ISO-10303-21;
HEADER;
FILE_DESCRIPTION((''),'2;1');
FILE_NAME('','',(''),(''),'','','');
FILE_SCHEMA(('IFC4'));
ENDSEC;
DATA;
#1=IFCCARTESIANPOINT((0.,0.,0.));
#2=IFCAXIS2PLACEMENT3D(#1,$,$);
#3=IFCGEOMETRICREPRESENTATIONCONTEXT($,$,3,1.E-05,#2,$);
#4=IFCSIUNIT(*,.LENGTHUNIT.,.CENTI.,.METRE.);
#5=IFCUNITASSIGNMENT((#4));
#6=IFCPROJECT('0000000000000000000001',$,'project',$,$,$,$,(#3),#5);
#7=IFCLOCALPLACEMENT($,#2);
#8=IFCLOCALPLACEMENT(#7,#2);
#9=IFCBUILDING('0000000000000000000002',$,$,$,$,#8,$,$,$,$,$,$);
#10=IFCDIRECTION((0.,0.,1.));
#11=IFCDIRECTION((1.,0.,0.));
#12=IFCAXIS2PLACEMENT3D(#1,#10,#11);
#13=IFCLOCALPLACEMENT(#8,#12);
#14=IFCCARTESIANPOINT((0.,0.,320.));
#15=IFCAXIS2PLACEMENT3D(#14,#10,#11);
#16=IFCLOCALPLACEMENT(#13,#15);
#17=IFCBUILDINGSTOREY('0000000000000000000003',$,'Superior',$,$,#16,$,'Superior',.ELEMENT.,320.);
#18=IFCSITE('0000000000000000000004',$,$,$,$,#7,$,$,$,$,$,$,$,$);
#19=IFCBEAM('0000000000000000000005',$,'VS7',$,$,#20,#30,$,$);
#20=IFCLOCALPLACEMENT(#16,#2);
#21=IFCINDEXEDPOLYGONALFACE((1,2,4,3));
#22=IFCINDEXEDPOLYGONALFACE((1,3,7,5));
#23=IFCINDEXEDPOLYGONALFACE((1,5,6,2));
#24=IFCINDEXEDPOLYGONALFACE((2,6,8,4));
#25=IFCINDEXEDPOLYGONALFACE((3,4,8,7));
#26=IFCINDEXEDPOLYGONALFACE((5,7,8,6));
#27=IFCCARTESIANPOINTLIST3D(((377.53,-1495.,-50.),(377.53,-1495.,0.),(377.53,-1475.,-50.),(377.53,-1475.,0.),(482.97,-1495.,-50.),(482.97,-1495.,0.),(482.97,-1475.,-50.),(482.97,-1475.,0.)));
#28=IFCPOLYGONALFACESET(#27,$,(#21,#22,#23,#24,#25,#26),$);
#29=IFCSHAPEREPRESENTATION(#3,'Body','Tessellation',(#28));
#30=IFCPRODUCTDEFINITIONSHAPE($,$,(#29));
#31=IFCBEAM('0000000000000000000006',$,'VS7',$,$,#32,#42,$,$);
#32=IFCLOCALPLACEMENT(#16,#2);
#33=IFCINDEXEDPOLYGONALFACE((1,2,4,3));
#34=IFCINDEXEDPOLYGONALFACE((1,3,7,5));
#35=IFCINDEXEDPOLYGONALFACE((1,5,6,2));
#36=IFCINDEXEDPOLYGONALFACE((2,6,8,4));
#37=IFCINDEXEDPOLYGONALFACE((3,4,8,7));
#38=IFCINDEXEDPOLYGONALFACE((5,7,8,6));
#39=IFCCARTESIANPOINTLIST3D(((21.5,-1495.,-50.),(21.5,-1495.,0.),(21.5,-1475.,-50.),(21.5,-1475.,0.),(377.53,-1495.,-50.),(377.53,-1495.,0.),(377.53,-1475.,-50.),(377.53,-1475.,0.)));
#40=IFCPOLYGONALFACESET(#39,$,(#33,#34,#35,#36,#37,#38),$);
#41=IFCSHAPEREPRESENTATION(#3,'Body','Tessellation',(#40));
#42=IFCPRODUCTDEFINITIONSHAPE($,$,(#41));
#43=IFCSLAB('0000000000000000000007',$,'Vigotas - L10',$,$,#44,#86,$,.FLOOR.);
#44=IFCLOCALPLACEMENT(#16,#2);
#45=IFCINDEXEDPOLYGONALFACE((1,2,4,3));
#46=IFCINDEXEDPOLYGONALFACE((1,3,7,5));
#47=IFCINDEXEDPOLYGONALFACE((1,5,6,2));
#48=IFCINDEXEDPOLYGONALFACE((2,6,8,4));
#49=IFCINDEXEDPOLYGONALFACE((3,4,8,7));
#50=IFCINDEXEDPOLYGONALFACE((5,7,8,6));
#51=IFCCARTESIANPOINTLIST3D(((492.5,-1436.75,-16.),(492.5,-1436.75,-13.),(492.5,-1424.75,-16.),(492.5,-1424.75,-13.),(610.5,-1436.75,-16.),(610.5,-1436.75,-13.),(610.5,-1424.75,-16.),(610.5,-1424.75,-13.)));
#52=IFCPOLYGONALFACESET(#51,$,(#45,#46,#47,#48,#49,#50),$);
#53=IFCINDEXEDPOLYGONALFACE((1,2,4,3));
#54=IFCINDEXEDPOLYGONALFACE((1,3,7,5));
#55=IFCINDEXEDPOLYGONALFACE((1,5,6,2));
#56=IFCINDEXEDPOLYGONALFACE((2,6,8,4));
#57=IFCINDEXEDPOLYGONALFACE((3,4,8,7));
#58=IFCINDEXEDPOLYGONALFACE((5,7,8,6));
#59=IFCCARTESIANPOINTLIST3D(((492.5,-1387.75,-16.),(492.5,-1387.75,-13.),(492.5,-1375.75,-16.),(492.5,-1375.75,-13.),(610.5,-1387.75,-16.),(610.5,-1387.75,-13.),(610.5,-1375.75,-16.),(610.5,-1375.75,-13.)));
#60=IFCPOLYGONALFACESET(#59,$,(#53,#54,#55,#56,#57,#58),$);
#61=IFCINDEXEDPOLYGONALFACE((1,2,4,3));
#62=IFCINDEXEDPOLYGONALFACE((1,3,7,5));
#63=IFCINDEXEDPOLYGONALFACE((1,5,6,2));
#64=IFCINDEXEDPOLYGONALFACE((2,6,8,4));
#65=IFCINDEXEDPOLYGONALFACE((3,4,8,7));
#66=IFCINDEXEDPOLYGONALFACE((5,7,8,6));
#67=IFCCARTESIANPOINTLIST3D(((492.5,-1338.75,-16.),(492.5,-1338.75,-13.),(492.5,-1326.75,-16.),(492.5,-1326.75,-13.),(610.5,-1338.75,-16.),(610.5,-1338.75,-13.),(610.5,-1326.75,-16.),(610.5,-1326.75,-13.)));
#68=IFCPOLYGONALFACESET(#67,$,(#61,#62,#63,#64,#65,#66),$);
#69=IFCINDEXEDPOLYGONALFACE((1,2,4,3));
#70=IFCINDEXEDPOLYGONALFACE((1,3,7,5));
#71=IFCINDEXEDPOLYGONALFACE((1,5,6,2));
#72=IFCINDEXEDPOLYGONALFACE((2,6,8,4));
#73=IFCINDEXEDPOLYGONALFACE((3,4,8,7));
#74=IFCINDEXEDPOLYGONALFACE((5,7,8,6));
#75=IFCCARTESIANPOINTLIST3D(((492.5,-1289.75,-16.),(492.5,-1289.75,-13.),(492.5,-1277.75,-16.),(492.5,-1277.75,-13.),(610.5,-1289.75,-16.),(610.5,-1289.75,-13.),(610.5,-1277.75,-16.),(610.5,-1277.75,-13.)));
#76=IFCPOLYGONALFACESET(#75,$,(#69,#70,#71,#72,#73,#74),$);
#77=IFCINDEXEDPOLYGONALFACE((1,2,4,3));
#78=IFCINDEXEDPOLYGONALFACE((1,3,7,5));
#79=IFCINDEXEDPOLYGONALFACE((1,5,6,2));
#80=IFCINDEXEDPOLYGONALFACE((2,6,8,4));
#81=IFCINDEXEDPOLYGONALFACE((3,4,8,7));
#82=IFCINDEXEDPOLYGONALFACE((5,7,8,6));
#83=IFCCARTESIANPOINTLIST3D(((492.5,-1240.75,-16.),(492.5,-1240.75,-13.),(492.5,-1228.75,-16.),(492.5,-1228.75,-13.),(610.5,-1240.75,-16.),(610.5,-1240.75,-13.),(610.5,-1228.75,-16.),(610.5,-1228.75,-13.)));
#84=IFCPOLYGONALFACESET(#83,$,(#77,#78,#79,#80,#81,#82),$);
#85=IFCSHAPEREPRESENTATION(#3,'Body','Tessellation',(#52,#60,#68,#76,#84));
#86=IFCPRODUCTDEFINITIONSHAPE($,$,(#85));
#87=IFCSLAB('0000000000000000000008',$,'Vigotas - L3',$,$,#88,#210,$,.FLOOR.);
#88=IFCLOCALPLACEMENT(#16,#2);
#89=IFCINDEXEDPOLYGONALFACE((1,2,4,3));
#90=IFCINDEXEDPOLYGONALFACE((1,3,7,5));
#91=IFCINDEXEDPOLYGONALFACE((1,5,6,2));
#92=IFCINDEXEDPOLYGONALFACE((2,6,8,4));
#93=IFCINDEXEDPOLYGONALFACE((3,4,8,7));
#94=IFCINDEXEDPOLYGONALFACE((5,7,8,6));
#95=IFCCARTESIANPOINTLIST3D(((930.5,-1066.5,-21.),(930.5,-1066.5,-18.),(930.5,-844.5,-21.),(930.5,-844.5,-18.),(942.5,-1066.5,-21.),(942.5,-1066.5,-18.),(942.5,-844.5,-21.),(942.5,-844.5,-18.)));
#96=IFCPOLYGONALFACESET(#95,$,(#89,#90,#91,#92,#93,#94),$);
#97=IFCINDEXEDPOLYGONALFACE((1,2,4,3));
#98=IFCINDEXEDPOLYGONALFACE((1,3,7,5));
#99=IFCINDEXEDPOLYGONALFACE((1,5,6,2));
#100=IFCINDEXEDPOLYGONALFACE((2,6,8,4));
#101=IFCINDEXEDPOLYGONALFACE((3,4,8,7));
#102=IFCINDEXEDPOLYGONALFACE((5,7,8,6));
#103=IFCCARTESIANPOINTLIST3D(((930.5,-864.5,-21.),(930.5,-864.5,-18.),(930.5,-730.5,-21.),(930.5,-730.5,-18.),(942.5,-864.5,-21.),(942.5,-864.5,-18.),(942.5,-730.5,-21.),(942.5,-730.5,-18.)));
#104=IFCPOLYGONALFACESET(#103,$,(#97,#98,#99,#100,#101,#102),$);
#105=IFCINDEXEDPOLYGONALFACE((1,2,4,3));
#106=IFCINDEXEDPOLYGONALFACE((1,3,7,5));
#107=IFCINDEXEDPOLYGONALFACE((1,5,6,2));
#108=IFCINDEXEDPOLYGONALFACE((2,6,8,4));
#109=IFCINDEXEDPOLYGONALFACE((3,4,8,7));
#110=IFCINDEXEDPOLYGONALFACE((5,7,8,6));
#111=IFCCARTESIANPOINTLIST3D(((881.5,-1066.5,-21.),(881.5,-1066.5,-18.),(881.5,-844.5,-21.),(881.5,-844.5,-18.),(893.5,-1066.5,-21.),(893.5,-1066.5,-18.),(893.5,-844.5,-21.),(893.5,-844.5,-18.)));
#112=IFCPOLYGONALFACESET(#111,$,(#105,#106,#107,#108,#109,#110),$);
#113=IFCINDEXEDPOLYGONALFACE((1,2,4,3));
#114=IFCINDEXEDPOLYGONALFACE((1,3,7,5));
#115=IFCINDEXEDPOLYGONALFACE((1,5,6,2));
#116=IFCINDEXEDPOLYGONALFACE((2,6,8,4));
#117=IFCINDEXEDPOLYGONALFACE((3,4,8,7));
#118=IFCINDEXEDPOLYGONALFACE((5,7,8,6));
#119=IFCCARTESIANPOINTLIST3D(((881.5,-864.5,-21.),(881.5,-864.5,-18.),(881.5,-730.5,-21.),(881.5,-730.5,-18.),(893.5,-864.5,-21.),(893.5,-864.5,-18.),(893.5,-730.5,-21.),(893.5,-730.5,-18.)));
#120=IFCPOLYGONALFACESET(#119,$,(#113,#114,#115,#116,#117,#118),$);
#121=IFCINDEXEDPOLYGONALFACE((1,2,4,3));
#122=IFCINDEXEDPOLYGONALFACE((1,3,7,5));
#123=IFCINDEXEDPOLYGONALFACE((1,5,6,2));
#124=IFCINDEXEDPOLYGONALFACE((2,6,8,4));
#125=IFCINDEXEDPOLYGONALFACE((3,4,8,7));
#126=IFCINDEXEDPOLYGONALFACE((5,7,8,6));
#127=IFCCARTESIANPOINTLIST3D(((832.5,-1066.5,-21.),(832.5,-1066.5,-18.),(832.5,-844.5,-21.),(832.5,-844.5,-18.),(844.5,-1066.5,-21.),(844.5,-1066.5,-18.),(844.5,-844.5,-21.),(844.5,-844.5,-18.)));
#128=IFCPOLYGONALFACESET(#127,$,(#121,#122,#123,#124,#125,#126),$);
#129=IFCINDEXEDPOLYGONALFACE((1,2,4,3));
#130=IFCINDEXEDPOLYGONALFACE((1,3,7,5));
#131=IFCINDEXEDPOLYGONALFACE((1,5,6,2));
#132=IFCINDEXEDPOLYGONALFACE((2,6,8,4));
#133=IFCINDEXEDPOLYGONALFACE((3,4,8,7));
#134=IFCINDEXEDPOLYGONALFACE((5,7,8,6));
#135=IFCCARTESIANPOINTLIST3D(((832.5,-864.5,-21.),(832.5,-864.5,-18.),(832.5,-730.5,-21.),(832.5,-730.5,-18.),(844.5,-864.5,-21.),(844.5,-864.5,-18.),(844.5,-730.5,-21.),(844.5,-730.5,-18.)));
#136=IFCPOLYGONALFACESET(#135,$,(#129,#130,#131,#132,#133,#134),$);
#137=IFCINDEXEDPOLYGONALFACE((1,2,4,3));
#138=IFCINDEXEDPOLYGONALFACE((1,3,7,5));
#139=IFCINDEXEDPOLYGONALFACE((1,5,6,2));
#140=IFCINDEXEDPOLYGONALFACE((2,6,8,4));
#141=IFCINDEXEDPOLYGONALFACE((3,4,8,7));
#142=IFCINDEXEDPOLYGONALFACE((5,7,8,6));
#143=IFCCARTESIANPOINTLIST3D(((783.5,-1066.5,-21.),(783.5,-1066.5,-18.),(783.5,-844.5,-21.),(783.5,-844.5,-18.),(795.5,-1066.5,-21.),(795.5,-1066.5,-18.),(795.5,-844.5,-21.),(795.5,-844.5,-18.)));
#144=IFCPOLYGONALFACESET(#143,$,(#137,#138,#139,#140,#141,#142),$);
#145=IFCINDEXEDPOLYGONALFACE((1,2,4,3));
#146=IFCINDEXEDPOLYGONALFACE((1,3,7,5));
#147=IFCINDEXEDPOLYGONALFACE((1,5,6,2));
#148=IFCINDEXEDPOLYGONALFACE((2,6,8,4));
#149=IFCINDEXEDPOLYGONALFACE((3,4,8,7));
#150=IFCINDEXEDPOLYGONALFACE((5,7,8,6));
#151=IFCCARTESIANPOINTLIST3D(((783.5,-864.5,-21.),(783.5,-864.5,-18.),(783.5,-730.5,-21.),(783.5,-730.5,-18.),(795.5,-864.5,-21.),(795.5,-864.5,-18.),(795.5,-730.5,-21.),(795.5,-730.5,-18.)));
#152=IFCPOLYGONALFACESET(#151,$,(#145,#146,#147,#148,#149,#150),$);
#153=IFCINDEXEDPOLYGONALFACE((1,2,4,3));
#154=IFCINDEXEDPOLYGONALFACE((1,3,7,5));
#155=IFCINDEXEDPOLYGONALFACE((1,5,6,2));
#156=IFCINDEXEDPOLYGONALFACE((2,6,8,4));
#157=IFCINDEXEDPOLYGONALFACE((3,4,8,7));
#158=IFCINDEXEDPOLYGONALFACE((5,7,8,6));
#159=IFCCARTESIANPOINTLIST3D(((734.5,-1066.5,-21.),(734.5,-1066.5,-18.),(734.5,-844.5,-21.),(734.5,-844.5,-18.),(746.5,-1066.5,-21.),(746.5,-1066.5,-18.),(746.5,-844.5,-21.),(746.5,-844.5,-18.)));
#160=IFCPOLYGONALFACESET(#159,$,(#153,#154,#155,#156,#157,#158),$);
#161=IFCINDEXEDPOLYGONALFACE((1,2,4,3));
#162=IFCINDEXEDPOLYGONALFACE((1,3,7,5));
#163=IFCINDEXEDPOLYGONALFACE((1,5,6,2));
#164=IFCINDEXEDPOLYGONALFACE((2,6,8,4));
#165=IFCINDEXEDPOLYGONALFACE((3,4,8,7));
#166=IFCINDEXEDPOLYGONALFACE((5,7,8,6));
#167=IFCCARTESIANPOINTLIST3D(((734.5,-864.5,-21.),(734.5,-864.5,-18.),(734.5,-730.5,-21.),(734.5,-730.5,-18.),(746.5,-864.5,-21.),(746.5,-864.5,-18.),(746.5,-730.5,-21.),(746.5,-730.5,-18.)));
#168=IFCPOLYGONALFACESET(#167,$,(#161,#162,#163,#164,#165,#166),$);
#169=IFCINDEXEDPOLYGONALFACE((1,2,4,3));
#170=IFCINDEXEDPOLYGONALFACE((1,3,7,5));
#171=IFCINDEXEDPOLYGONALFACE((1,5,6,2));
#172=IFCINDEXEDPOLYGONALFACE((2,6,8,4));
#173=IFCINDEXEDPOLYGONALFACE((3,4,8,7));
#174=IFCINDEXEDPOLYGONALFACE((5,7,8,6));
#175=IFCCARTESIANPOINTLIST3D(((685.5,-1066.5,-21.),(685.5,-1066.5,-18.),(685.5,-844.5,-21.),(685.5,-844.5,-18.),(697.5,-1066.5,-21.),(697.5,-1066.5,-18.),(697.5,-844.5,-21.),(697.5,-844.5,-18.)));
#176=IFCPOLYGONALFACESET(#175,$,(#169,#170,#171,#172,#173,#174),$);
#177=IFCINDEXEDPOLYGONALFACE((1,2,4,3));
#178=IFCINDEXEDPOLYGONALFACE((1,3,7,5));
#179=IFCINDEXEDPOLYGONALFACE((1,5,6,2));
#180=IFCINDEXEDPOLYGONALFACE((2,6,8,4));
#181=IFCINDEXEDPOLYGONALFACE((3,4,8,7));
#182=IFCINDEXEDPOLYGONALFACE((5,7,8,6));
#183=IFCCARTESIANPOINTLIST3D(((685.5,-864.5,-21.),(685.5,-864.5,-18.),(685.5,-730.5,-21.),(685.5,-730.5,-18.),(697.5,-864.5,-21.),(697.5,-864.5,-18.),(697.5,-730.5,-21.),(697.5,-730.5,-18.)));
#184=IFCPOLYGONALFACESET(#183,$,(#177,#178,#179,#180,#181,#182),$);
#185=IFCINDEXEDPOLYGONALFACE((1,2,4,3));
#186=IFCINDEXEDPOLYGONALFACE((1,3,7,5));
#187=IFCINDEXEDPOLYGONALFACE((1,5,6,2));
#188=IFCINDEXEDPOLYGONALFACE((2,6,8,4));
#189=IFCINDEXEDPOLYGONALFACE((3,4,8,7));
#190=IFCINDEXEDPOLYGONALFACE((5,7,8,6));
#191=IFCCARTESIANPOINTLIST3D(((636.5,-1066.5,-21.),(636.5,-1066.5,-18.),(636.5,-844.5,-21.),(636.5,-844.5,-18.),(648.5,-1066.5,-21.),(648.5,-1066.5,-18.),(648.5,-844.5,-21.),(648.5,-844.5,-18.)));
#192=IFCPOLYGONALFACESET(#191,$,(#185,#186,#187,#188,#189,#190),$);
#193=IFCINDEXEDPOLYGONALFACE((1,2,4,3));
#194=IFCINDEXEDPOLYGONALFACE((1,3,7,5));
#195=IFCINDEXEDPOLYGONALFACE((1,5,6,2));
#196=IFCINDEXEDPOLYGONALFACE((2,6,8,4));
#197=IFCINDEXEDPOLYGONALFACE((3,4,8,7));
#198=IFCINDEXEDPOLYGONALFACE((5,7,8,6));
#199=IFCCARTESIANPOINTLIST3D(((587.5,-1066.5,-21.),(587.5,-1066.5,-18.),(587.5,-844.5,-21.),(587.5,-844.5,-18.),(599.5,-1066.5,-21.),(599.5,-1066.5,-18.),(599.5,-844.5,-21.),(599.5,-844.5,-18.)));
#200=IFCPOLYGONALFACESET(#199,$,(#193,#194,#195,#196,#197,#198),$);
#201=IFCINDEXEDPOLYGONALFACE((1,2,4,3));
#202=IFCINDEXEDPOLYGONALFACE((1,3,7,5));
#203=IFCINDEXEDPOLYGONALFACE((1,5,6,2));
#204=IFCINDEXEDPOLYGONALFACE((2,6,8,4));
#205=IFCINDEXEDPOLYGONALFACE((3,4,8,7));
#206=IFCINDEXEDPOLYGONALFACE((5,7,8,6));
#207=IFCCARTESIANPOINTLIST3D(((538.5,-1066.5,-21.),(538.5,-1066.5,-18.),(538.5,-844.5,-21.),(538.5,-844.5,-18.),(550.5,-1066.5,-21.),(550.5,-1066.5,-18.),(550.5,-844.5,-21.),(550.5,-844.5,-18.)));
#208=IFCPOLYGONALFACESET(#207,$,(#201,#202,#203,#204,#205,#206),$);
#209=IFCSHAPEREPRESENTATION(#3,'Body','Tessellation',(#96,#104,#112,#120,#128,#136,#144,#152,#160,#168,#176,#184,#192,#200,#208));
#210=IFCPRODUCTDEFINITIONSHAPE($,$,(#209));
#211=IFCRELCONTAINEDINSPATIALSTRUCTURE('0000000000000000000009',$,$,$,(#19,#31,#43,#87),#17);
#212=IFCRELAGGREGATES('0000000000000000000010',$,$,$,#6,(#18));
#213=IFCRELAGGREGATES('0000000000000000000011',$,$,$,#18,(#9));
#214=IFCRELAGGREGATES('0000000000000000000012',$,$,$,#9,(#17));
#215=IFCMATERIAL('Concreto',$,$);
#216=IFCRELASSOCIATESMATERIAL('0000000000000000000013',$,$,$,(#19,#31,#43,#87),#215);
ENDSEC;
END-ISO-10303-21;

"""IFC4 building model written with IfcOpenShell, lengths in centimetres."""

from ifc_helpers import new_model, si_unit, frame, origin, origin_with_axes, place, context, project, spatial, polyline, outline, extrude, material, element, save


model = new_model("IFC4")

# Units and contexts
context_of_model = context(None, 3, precision=1e-05, world=origin())
ifc_project = project(units=[si_unit("LENGTHUNIT", "METRE", prefix="CENTI")], contexts=[context_of_model])

# Site, building, storey
site_placement = place(None, origin())
site = spatial("IfcSite", under=ifc_project, at=site_placement)
building_placement = place(site_placement, origin())
building = spatial("IfcBuilding", under=site, at=building_placement)
placement = place(building_placement, origin_with_axes())
storey_placement = place(placement, frame((0.0, 0.0, 320.0), z_axis=(0.0, 0.0, 1.0), x_axis=(1.0, 0.0, 0.0)))
storey = spatial("IfcBuildingStorey", under=building, at=storey_placement, Name="Superior", LongName="Superior", CompositionType="ELEMENT", Elevation=320.0)

# Shared definitions
ifc_material = material(Name="Concreto")

# Beams
beam_1_placement = place(storey_placement, frame((430.25, -1485.0, 0.0), z_axis=(0.0, 0.0, 1.0), x_axis=(1.0, 0.0, 0.0)))
element("IfcBeam", 1, at=beam_1_placement, inside=storey, material=ifc_material, Name="VS7", context=context_of_model, shape_type="SolidModel", body=[
    extrude(outline(polyline([(-10.0, -25.0), (10.0, -25.0), (10.0, 25.0), (-10.0, 25.0), (-10.0, -25.0)])), frame((-52.72, 0.0, -25.0), z_axis=(1.0, 0.0, 0.0), x_axis=(0.0, -1.0, 0.0)), (0.0, 0.0, 1.0), 105.44),
])
beam_2_placement = place(storey_placement, frame((199.51, -1485.0, 0.0), z_axis=(0.0, 0.0, 1.0), x_axis=(1.0, 0.0, 0.0)))
element("IfcBeam", 2, at=beam_2_placement, inside=storey, material=ifc_material, Name="VS7", context=context_of_model, shape_type="SolidModel", body=[
    extrude(outline(polyline([(-10.0, -25.0), (10.0, -25.0), (10.0, 25.0), (-10.0, 25.0), (-10.0, -25.0)])), frame((-178.01, 0.0, -25.0), z_axis=(1.0, 0.0, 0.0), x_axis=(0.0, -1.0, 0.0)), (0.0, 0.0, 1.0), 356.03),
])

# Slabs
slab_1_placement = place(storey_placement, frame((551.5, -1332.75, -13.0), z_axis=(0.0, 0.0, 1.0), x_axis=(1.0, 0.0, 0.0)))
element("IfcSlab", 3, at=slab_1_placement, inside=storey, material=ifc_material, Name="Vigotas - L10", PredefinedType="FLOOR", context=context_of_model, shape_type="SolidModel", body=[
    extrude(outline(polyline([(6.0, 1.5), (-6.0, 1.5), (-6.0, -1.5), (6.0, -1.5), (6.0, 1.5), (6.0, 1.5)])), frame((-59.0, -98.0, -1.5), z_axis=(1.0, 0.0, 0.0), x_axis=(0.0, -1.0, 0.0)), (0.0, 0.0, 1.0), 118.0),
    extrude(outline(polyline([(6.0, 1.5), (-6.0, 1.5), (-6.0, -1.5), (6.0, -1.5), (6.0, 1.5), (6.0, 1.5)])), frame((-59.0, -49.0, -1.5), z_axis=(1.0, 0.0, 0.0), x_axis=(0.0, -1.0, 0.0)), (0.0, 0.0, 1.0), 118.0),
    extrude(outline(polyline([(6.0, 1.5), (-6.0, 1.5), (-6.0, -1.5), (6.0, -1.5), (6.0, 1.5), (6.0, 1.5)])), frame((-59.0, 0.0, -1.5), z_axis=(1.0, 0.0, 0.0), x_axis=(0.0, -1.0, 0.0)), (0.0, 0.0, 1.0), 118.0),
    extrude(outline(polyline([(6.0, 1.5), (-6.0, 1.5), (-6.0, -1.5), (6.0, -1.5), (6.0, 1.5), (6.0, 1.5)])), frame((-59.0, 49.0, -1.5), z_axis=(1.0, 0.0, 0.0), x_axis=(0.0, -1.0, 0.0)), (0.0, 0.0, 1.0), 118.0),
    extrude(outline(polyline([(6.0, 1.5), (-6.0, 1.5), (-6.0, -1.5), (6.0, -1.5), (6.0, 1.5), (6.0, 1.5)])), frame((-59.0, 98.0, -1.5), z_axis=(1.0, 0.0, 0.0), x_axis=(0.0, -1.0, 0.0)), (0.0, 0.0, 1.0), 118.0),
])
slab_2_placement = place(storey_placement, frame((740.5, -898.5, -18.0), z_axis=(0.0, 0.0, 1.0), x_axis=(1.0, 0.0, 0.0)))
element("IfcSlab", 4, at=slab_2_placement, inside=storey, material=ifc_material, Name="Vigotas - L3", PredefinedType="FLOOR", context=context_of_model, shape_type="SolidModel", body=[
    extrude(outline(polyline([(6.0, 1.5), (-6.0, 1.5), (-6.0, -1.5), (6.0, -1.5), (6.0, 1.5), (6.0, 1.5)])), frame((196.0, -168.0, -1.5), z_axis=(0.0, 1.0, 0.0), x_axis=(1.0, 0.0, 0.0)), (0.0, 0.0, 1.0), 222.0),
    extrude(outline(polyline([(6.0, 1.5), (-6.0, 1.5), (-6.0, -1.5), (6.0, -1.5), (6.0, 1.5), (6.0, 1.5)])), frame((196.0, 34.0, -1.5), z_axis=(0.0, 1.0, 0.0), x_axis=(1.0, 0.0, 0.0)), (0.0, 0.0, 1.0), 134.0),
    extrude(outline(polyline([(6.0, 1.5), (-6.0, 1.5), (-6.0, -1.5), (6.0, -1.5), (6.0, 1.5), (6.0, 1.5)])), frame((147.0, -168.0, -1.5), z_axis=(0.0, 1.0, 0.0), x_axis=(1.0, 0.0, 0.0)), (0.0, 0.0, 1.0), 222.0),
    extrude(outline(polyline([(6.0, 1.5), (-6.0, 1.5), (-6.0, -1.5), (6.0, -1.5), (6.0, 1.5), (6.0, 1.5)])), frame((147.0, 34.0, -1.5), z_axis=(0.0, 1.0, 0.0), x_axis=(1.0, 0.0, 0.0)), (0.0, 0.0, 1.0), 134.0),
    extrude(outline(polyline([(6.0, 1.5), (-6.0, 1.5), (-6.0, -1.5), (6.0, -1.5), (6.0, 1.5), (6.0, 1.5)])), frame((98.0, -168.0, -1.5), z_axis=(0.0, 1.0, 0.0), x_axis=(1.0, 0.0, 0.0)), (0.0, 0.0, 1.0), 222.0),
    extrude(outline(polyline([(6.0, 1.5), (-6.0, 1.5), (-6.0, -1.5), (6.0, -1.5), (6.0, 1.5), (6.0, 1.5)])), frame((98.0, 34.0, -1.5), z_axis=(0.0, 1.0, 0.0), x_axis=(1.0, 0.0, 0.0)), (0.0, 0.0, 1.0), 134.0),
    extrude(outline(polyline([(6.0, 1.5), (-6.0, 1.5), (-6.0, -1.5), (6.0, -1.5), (6.0, 1.5), (6.0, 1.5)])), frame((49.0, -168.0, -1.5), z_axis=(0.0, 1.0, 0.0), x_axis=(1.0, 0.0, 0.0)), (0.0, 0.0, 1.0), 222.0),
    extrude(outline(polyline([(6.0, 1.5), (-6.0, 1.5), (-6.0, -1.5), (6.0, -1.5), (6.0, 1.5), (6.0, 1.5)])), frame((49.0, 34.0, -1.5), z_axis=(0.0, 1.0, 0.0), x_axis=(1.0, 0.0, 0.0)), (0.0, 0.0, 1.0), 134.0),
    extrude(outline(polyline([(6.0, 1.5), (-6.0, 1.5), (-6.0, -1.5), (6.0, -1.5), (6.0, 1.5), (6.0, 1.5)])), frame((0.0, -168.0, -1.5), z_axis=(0.0, 1.0, 0.0), x_axis=(1.0, 0.0, 0.0)), (0.0, 0.0, 1.0), 222.0),
    extrude(outline(polyline([(6.0, 1.5), (-6.0, 1.5), (-6.0, -1.5), (6.0, -1.5), (6.0, 1.5), (6.0, 1.5)])), frame((0.0, 34.0, -1.5), z_axis=(0.0, 1.0, 0.0), x_axis=(1.0, 0.0, 0.0)), (0.0, 0.0, 1.0), 134.0),
    extrude(outline(polyline([(6.0, 1.5), (-6.0, 1.5), (-6.0, -1.5), (6.0, -1.5), (6.0, 1.5), (6.0, 1.5)])), frame((-49.0, -168.0, -1.5), z_axis=(0.0, 1.0, 0.0), x_axis=(1.0, 0.0, 0.0)), (0.0, 0.0, 1.0), 222.0),
    extrude(outline(polyline([(6.0, 1.5), (-6.0, 1.5), (-6.0, -1.5), (6.0, -1.5), (6.0, 1.5), (6.0, 1.5)])), frame((-49.0, 34.0, -1.5), z_axis=(0.0, 1.0, 0.0), x_axis=(1.0, 0.0, 0.0)), (0.0, 0.0, 1.0), 134.0),
    extrude(outline(polyline([(6.0, 1.5), (-6.0, 1.5), (-6.0, -1.5), (6.0, -1.5), (6.0, 1.5), (6.0, 1.5)])), frame((-98.0, -168.0, -1.5), z_axis=(0.0, 1.0, 0.0), x_axis=(1.0, 0.0, 0.0)), (0.0, 0.0, 1.0), 222.0),
    extrude(outline(polyline([(6.0, 1.5), (-6.0, 1.5), (-6.0, -1.5), (6.0, -1.5), (6.0, 1.5), (6.0, 1.5)])), frame((-147.0, -168.0, -1.5), z_axis=(0.0, 1.0, 0.0), x_axis=(1.0, 0.0, 0.0)), (0.0, 0.0, 1.0), 222.0),
    extrude(outline(polyline([(6.0, 1.5), (-6.0, 1.5), (-6.0, -1.5), (6.0, -1.5), (6.0, 1.5), (6.0, 1.5)])), frame((-196.0, -168.0, -1.5), z_axis=(0.0, 1.0, 0.0), x_axis=(1.0, 0.0, 0.0)), (0.0, 0.0, 1.0), 222.0),
])

save(model, "model.ifc")
